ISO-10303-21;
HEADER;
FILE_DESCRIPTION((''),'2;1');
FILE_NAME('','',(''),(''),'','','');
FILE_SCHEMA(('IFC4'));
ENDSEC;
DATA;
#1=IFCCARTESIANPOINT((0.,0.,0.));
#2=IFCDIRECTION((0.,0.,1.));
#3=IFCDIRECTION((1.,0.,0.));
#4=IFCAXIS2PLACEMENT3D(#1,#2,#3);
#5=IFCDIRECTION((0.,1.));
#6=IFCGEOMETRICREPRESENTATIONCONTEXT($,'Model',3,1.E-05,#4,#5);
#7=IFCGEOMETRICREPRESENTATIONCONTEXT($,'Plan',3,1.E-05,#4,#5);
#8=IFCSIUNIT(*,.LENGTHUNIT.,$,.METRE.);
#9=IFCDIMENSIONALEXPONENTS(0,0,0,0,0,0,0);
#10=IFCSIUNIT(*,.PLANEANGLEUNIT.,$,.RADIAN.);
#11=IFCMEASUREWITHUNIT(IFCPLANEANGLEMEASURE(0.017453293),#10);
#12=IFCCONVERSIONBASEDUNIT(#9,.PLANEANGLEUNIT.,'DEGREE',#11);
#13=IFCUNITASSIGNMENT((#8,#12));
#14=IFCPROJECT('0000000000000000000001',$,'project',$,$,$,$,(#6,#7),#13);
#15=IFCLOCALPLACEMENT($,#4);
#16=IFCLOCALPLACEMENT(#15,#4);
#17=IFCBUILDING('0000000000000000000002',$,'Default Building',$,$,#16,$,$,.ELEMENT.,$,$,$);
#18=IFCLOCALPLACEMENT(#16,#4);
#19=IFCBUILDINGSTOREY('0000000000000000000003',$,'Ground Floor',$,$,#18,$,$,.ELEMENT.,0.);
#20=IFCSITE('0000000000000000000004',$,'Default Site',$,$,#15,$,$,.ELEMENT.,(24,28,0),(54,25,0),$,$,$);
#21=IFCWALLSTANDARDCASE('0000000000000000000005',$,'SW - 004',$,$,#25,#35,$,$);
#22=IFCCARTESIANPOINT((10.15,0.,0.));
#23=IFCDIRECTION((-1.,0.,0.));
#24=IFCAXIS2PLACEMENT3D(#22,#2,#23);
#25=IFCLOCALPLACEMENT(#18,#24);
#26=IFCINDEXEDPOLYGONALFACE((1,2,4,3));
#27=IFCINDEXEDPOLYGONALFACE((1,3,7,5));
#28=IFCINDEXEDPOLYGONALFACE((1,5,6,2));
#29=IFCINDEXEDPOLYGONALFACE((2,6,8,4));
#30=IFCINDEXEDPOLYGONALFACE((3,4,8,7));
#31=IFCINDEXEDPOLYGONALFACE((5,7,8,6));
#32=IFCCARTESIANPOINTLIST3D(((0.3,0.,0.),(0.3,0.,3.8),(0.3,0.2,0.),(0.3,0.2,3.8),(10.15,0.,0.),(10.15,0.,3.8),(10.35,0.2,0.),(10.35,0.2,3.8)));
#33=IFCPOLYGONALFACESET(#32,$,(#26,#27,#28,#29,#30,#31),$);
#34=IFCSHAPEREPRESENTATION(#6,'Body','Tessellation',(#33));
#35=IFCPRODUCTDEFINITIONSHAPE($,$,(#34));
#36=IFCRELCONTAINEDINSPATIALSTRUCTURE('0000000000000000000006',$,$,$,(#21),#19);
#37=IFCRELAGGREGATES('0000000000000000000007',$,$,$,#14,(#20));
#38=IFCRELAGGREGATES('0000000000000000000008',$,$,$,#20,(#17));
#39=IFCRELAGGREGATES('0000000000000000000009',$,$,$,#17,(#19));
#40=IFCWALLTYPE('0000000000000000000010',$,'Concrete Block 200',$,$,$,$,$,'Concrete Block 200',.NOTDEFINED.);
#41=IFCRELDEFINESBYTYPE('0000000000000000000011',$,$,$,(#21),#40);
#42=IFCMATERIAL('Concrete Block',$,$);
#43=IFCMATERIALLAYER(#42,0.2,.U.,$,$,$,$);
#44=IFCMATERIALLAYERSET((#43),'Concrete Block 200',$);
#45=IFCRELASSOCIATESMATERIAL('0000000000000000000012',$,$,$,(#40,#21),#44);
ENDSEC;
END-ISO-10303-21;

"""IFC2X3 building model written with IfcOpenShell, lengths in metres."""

from ifc_helpers import new_model, entity, si_unit, converted_unit, direction, frame, origin_with_axes, place, context, project, spatial, polyline, outline, extrude, material, layer, layer_set, layer_usage, type_object, element, save


model = new_model("IFC2X3")

# Units and contexts
model_context = context("Model", 3, precision=1e-05, world=origin_with_axes(), true_north=direction((0.0, 1.0)))
plan_context = context("Plan", 3, precision=1e-05, world=origin_with_axes(), true_north=direction((0.0, 1.0)))
ifc_project = project(units=[si_unit("LENGTHUNIT", "METRE"), converted_unit("PLANEANGLEUNIT", "DEGREE", entity("IfcPlaneAngleMeasure", 0.017453293), si_unit("PLANEANGLEUNIT", "RADIAN"), dimensions=[0, 0, 0, 0, 0, 0, 0])], contexts=[model_context, plan_context])

# Site, building, storey
site_placement = place(None, origin_with_axes())
site = spatial("IfcSite", under=ifc_project, at=site_placement, Name="Default Site", CompositionType="ELEMENT", RefLatitude=(24, 28, 0), RefLongitude=(54, 25, 0))
building_placement = place(site_placement, origin_with_axes())
building = spatial("IfcBuilding", under=site, at=building_placement, Name="Default Building", CompositionType="ELEMENT")
storey_placement = place(building_placement, origin_with_axes())
storey = spatial("IfcBuildingStorey", under=building, at=storey_placement, Name="Ground Floor", CompositionType="ELEMENT", Elevation=0.0)

# Shared definitions
ifc_material = material(Name="Concrete Block")
ifc_layer_1 = layer(ifc_material, 0.2, ventilated="UNKNOWN")
ifc_layer_set_1 = layer_set([ifc_layer_1], Name="Concrete Block 200")

# Wall
wall_type_1 = type_object("IfcWallType", Name="Concrete Block 200", ElementType="Concrete Block 200", PredefinedType="NOTDEFINED", material=ifc_layer_set_1)
ifc_layer_usage_1 = layer_usage(ifc_layer_set_1, "AXIS2", "POSITIVE", 0.0)
wall_1_placement = place(storey_placement, frame((10.15, 0.0, 0.0), z_axis=(0.0, 0.0, 1.0), x_axis=(-1.0, 0.0, 0.0)))
element("IfcWallStandardCase", 1, at=wall_1_placement, inside=storey, type_object=wall_type_1, material=ifc_layer_usage_1, Name="SW - 004", context=model_context, shape_type="SweptSolid", body=[
    extrude(outline(polyline([(0.3, 0.0), (10.15, 0.0), (10.35, 0.2), (0.3, 0.2), (0.3, 0.0)])), origin_with_axes(), (0.0, 0.0, 1.0), 3.8),
])

save(model, "model.ifc")
